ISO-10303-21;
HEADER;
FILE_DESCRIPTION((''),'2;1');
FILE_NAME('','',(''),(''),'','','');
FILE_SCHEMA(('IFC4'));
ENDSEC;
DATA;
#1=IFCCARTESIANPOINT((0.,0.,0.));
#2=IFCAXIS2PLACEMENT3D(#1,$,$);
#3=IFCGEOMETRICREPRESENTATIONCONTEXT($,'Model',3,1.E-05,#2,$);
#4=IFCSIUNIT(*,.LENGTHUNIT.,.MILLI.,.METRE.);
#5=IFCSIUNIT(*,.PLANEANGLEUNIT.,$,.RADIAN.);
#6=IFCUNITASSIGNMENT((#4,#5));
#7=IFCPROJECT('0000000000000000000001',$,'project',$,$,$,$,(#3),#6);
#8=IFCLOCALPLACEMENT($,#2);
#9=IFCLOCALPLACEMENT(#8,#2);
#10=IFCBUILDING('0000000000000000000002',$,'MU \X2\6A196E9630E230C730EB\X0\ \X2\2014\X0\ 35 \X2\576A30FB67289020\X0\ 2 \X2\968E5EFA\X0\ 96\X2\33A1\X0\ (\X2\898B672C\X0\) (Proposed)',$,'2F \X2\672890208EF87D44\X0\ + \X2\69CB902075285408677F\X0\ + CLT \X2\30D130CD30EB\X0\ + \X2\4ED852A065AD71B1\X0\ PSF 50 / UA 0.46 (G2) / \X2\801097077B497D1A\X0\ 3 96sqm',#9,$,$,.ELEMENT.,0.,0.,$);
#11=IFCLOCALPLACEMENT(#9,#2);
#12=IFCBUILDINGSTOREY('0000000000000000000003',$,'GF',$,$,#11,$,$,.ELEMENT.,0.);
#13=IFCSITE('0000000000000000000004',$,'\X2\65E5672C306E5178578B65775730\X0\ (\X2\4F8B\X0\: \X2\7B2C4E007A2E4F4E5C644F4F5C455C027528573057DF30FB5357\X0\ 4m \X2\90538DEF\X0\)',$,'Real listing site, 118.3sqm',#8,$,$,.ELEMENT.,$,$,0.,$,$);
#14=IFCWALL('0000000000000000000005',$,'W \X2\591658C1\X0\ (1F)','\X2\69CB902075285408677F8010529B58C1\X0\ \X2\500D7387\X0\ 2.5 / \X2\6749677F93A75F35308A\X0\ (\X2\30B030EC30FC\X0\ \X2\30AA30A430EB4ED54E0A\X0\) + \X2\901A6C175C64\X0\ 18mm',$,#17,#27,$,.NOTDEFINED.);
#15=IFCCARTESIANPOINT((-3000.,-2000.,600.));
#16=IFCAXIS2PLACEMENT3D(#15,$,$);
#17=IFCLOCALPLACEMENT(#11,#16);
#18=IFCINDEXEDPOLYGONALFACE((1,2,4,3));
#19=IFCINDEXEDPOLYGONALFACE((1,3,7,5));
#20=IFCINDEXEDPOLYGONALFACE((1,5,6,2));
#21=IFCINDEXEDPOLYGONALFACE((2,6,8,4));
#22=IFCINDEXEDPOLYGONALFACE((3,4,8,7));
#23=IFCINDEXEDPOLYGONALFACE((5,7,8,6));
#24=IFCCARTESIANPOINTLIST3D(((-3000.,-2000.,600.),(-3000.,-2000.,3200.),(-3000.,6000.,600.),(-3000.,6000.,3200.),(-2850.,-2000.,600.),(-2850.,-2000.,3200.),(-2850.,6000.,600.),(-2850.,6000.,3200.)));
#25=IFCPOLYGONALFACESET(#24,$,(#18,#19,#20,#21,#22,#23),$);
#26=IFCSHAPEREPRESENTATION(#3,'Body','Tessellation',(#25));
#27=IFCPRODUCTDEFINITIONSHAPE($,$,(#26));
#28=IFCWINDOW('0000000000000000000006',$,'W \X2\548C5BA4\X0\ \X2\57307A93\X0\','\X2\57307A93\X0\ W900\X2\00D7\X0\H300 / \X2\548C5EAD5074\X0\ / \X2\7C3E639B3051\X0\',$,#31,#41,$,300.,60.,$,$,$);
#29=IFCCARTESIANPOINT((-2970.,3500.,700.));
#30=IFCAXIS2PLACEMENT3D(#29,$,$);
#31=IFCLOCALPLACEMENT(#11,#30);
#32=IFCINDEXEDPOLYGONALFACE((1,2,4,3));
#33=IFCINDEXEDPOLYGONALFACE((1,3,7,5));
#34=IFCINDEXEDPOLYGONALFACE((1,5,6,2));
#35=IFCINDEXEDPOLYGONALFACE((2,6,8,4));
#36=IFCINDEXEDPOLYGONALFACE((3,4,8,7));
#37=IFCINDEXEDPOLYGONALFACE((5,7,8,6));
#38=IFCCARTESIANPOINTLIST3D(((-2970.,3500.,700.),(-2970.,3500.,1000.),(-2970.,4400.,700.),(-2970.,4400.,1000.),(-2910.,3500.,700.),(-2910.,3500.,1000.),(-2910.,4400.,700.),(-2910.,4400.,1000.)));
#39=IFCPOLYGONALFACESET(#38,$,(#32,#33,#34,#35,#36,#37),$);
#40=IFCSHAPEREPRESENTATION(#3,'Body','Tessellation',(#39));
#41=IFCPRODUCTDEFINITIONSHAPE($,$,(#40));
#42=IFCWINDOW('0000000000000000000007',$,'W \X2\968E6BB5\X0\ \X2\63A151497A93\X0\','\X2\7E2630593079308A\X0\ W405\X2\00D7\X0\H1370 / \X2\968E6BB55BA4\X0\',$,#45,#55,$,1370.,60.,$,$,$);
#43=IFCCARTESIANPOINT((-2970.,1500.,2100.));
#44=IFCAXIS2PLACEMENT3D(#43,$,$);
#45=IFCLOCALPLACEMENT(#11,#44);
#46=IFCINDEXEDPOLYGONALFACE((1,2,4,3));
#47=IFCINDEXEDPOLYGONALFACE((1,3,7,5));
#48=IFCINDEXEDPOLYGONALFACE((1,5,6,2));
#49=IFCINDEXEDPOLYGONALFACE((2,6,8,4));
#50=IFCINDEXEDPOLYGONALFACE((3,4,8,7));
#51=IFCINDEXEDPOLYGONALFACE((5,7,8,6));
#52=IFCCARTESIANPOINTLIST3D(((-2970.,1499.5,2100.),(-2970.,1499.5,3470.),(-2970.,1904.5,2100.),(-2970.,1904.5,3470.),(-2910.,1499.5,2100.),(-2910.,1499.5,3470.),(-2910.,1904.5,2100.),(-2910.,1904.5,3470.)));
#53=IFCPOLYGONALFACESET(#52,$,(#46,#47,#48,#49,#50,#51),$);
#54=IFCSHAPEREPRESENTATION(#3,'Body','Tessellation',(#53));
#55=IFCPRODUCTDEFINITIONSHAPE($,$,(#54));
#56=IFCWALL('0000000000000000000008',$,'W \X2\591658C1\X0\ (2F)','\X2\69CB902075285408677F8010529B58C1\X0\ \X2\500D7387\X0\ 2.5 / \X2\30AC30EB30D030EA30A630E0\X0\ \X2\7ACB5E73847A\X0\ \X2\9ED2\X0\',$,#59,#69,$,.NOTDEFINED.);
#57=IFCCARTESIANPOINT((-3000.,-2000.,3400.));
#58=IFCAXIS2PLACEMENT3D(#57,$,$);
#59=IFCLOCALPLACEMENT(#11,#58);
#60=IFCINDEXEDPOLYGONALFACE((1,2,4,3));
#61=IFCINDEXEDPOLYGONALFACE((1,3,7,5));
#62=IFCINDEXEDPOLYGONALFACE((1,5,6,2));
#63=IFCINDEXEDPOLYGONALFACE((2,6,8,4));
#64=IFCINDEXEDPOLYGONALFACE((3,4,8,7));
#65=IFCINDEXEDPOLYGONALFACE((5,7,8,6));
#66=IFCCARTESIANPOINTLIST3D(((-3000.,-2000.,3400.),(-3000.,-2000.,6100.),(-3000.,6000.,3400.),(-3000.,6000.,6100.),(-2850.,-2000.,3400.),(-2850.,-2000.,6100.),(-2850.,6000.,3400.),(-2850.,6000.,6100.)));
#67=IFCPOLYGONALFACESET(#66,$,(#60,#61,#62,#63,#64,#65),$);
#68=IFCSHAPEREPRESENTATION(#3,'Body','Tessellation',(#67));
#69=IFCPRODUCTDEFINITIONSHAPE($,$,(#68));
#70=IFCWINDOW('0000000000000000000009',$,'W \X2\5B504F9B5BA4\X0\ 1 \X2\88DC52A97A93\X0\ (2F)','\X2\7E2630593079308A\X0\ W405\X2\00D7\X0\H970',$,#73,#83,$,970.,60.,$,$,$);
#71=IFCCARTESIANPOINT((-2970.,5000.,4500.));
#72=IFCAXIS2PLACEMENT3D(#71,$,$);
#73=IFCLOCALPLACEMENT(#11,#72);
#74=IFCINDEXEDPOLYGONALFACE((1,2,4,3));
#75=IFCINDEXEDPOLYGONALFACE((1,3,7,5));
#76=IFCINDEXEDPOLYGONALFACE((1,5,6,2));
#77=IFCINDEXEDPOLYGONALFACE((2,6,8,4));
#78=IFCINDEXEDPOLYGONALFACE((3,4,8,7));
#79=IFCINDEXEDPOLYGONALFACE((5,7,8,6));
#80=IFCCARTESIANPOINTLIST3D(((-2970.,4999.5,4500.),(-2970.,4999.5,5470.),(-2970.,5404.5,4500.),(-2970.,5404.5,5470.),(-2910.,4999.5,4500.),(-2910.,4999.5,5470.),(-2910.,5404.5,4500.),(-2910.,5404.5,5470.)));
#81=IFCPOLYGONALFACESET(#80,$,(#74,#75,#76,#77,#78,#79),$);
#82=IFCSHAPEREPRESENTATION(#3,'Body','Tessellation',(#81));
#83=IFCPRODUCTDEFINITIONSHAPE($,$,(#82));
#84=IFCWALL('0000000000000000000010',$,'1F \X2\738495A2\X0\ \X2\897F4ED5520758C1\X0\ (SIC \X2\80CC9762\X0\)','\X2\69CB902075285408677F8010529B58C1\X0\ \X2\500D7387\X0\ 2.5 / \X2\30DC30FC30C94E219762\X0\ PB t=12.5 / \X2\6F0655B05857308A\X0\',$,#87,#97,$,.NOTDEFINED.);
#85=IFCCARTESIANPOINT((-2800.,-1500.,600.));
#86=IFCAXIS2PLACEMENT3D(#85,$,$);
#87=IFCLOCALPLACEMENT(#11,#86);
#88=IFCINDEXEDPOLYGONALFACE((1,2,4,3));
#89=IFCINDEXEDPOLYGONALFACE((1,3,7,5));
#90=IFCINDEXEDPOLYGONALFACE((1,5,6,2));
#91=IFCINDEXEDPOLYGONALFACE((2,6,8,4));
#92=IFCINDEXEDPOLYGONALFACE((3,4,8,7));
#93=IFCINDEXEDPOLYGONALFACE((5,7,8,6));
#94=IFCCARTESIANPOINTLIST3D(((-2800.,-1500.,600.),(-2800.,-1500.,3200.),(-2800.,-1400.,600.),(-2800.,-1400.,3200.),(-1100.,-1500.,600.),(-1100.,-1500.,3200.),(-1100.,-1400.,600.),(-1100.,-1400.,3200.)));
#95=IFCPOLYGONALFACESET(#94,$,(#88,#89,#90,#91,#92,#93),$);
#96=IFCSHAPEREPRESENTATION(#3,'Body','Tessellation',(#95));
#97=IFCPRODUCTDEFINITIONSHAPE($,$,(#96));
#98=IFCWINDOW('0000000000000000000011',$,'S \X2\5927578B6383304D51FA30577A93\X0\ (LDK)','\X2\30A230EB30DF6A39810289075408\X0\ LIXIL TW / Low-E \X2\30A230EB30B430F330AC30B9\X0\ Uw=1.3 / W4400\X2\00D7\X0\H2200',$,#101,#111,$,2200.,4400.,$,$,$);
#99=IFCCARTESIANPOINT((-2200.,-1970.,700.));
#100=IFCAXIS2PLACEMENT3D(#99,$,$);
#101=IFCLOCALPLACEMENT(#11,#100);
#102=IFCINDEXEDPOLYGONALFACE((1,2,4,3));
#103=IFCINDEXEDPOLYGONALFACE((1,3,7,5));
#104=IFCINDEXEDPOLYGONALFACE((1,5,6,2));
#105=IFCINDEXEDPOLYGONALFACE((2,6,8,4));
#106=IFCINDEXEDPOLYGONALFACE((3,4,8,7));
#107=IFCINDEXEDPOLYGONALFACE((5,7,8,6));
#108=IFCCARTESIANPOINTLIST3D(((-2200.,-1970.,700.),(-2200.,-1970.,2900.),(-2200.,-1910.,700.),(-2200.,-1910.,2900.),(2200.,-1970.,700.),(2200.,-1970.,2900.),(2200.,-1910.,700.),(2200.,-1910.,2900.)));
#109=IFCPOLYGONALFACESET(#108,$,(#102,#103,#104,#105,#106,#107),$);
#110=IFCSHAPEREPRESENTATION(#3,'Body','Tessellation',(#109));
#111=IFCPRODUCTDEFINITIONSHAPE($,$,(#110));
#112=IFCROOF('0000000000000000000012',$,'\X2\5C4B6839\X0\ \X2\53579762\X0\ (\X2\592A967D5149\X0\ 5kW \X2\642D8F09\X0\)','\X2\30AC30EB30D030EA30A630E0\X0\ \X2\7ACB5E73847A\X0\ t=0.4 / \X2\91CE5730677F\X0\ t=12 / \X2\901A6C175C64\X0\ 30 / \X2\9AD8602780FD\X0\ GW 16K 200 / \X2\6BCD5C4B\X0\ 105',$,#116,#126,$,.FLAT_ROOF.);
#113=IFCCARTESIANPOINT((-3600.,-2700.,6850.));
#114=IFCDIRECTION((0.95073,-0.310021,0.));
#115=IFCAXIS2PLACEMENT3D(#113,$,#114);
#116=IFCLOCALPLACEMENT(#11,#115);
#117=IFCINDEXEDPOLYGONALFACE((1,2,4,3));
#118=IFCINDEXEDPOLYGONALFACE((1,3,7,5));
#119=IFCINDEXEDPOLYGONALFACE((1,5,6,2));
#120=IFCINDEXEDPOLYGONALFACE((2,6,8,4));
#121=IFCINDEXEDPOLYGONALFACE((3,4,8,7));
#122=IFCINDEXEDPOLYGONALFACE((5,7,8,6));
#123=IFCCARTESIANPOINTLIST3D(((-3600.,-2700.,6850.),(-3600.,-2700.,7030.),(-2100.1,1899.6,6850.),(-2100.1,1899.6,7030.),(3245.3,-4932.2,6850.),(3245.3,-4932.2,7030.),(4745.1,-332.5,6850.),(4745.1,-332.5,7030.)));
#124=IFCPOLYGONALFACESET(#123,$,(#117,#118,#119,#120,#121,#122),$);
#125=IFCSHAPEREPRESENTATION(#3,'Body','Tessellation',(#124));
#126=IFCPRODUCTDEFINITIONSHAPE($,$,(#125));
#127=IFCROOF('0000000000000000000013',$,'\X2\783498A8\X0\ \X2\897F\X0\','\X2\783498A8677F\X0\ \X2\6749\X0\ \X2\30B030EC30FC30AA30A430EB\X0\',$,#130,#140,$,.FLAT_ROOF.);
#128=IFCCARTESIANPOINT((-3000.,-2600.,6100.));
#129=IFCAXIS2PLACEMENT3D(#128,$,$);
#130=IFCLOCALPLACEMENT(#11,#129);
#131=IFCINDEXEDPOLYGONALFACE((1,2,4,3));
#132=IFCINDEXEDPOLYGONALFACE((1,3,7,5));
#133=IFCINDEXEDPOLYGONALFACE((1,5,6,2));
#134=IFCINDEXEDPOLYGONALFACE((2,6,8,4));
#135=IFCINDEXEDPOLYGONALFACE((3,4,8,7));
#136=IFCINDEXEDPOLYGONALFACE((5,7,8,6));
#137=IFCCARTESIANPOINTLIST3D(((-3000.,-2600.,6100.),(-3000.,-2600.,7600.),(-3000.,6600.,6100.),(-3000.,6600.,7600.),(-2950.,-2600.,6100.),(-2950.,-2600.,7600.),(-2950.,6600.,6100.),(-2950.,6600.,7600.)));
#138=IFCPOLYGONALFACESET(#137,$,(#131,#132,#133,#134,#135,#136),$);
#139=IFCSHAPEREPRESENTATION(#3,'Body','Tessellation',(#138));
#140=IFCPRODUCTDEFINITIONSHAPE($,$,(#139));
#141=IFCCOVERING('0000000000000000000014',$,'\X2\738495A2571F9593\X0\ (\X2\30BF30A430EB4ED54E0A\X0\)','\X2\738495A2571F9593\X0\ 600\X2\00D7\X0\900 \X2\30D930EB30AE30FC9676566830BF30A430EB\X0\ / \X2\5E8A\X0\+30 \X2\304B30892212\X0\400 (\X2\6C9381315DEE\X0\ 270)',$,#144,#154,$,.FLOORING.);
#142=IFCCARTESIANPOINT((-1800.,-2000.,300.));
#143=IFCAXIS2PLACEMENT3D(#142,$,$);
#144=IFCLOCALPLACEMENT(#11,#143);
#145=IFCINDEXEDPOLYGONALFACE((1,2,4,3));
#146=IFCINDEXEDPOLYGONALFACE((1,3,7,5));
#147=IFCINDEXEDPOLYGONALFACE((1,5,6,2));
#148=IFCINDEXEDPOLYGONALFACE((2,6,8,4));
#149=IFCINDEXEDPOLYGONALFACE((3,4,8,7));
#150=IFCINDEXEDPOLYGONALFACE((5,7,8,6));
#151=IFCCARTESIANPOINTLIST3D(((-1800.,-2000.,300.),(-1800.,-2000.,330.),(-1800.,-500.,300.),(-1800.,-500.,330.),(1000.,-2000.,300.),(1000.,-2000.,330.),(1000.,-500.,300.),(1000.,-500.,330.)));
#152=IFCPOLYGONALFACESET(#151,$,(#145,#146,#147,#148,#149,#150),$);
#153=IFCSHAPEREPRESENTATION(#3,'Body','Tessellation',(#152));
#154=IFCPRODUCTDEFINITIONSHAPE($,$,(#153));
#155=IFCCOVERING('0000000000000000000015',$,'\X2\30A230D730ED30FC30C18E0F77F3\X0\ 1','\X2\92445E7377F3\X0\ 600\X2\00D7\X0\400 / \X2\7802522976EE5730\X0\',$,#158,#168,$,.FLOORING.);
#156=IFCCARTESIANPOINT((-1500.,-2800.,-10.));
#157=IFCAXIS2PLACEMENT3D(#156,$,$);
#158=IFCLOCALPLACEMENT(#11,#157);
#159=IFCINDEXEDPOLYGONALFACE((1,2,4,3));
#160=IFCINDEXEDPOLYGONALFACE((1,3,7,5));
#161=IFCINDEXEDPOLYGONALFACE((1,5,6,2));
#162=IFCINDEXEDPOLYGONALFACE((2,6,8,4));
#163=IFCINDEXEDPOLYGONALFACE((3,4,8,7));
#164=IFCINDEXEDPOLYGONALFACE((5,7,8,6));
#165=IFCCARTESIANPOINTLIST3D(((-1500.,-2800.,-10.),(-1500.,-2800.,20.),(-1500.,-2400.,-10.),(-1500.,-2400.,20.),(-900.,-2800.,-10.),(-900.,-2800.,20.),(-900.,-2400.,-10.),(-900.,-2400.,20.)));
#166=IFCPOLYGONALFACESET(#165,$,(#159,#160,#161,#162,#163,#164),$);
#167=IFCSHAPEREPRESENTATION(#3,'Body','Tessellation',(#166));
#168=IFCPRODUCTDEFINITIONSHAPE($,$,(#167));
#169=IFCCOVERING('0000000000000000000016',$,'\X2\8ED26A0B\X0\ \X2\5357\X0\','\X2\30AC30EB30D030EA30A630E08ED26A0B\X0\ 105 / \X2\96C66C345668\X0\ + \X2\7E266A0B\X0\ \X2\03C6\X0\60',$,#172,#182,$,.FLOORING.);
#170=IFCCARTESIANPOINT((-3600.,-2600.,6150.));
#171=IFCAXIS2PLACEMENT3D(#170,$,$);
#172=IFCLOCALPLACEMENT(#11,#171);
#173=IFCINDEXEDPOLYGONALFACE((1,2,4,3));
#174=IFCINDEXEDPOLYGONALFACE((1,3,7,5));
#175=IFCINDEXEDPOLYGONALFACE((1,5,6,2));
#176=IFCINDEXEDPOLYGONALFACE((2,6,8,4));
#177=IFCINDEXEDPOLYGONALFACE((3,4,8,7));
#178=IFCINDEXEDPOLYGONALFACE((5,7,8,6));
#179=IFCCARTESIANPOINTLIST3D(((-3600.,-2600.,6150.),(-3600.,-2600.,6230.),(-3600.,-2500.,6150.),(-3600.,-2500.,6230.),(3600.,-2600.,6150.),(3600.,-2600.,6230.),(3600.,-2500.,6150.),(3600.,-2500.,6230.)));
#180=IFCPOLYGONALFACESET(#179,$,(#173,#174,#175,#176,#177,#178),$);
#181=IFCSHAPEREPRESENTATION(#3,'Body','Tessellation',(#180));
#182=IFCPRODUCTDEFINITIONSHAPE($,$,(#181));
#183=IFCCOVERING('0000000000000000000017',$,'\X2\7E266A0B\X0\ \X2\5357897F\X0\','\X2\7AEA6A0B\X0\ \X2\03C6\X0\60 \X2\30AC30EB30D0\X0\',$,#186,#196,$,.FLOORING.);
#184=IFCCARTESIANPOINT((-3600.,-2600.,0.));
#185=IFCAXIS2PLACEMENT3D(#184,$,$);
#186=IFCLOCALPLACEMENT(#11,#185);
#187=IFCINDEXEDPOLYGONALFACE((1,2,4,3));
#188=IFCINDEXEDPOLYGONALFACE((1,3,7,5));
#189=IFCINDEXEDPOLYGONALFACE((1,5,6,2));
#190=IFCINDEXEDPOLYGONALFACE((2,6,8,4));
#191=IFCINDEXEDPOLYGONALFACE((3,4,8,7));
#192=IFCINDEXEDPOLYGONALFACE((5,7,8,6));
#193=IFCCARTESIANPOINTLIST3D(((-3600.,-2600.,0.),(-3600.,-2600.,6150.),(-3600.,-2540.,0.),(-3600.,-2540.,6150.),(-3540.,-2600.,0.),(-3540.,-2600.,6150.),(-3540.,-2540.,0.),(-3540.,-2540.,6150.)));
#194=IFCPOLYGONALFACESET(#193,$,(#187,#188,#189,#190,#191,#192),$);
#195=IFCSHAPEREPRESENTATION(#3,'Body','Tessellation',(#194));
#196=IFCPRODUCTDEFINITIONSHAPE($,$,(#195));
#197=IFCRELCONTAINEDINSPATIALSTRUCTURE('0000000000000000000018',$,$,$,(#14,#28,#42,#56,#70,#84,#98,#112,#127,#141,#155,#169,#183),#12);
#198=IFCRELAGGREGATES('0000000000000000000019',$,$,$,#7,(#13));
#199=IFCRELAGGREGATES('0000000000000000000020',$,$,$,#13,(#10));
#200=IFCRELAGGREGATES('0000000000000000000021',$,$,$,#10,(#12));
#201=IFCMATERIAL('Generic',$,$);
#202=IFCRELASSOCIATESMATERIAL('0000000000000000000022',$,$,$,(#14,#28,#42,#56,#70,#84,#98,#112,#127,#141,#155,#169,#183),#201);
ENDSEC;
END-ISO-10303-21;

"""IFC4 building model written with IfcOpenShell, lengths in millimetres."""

from ifc_helpers import new_model, si_unit, frame, frame_2d, origin, place, context, project, spatial, rectangle, extrude, material, element, fill, save


model = new_model("IFC4")

# Units and contexts
model_context = context("Model", 3, precision=1e-05, world=origin())
ifc_project = project(units=[si_unit("LENGTHUNIT", "METRE", prefix="MILLI"), si_unit("PLANEANGLEUNIT", "RADIAN")], contexts=[model_context])

# Site, building, storey
site_placement = place(None, origin())
site = spatial("IfcSite", under=ifc_project, at=site_placement, Name="日本の典型敷地 (例: 第一種低層住居専用地域・南 4m 道路)", ObjectType="Real listing site, 118.3sqm", CompositionType="ELEMENT", RefElevation=0.0)
building_placement = place(site_placement, origin())
building = spatial("IfcBuilding", under=site, at=building_placement, Name="MU 標準モデル — 35 坪・木造 2 階建 96㎡ (見本) (Proposed)", ObjectType="2F 木造軸組 + 構造用合板 + CLT パネル + 付加断熱 PSF 50 / UA 0.46 (G2) / 耐震等級 3 96sqm", CompositionType="ELEMENT", ElevationOfRefHeight=0.0, ElevationOfTerrain=0.0)
storey_placement = place(building_placement, origin())
storey = spatial("IfcBuildingStorey", under=building, at=storey_placement, Name="GF", CompositionType="ELEMENT", Elevation=0.0)

# Shared definitions
ifc_material_1 = material(Name="Generic")

# Wall, openings, windows
wall_1_placement = place(storey_placement, frame((-3000.0, -2000.0, 600.0)))
wall_1 = element("IfcWall", 1, at=wall_1_placement, inside=storey, material=ifc_material_1, Name="W 外壁 (1F)", Description="構造用合板耐力壁 倍率 2.5 / 杉板鎧張り (グレー オイル仕上) + 通気層 18mm", PredefinedType="NOTDEFINED", context=model_context, shape_type="SweptSolid", body=[
    extrude(rectangle(XDim=150.0, YDim=8000.0, at=frame_2d((75.0, 4000.0))), frame((-3000.0, -2000.0, 600.0)), (0.0, 0.0, 1.0), 2600.0),
])
opening_1_placement = place(storey_placement, frame((-2970.0, 3500.0, 700.0)))
opening_1 = element("IfcOpeningElement", 2, at=opening_1_placement, cuts=wall_1, PredefinedType="NOTDEFINED", context=model_context, shape_type="SweptSolid", body=[
    extrude(rectangle(XDim=60.0, YDim=900.0, at=frame_2d((30.0, 450.0))), frame((-2970.0, 3500.0, 700.0)), (0.0, 0.0, 1.0), 300.0),
])
opening_2_placement = place(storey_placement, frame((-2970.0, 1500.0, 2100.0)))
opening_2 = element("IfcOpeningElement", 3, at=opening_2_placement, cuts=wall_1, PredefinedType="NOTDEFINED", context=model_context, shape_type="SweptSolid", body=[
    extrude(rectangle(XDim=60.0, YDim=405.0, at=frame_2d((30.0, 202.0))), frame((-2970.0, 1500.0, 2100.0)), (0.0, 0.0, 1.0), 1370.0),
])
window_1_placement = place(storey_placement, frame((-2970.0, 3500.0, 700.0)))
window_1 = element("IfcWindow", 4, at=window_1_placement, inside=storey, material=ifc_material_1, Name="W 和室 地窓", Description="地窓 W900×H300 / 和庭側 / 簾掛け", OverallHeight=300.0, OverallWidth=60.0, context=model_context, shape_type="SweptSolid", body=[
    extrude(rectangle(XDim=60.0, YDim=900.0, at=frame_2d((30.0, 450.0))), frame((-2970.0, 3500.0, 700.0)), (0.0, 0.0, 1.0), 300.0),
])
fill(opening_1, window_1)
window_2_placement = place(storey_placement, frame((-2970.0, 1500.0, 2100.0)))
window_2 = element("IfcWindow", 5, at=window_2_placement, inside=storey, material=ifc_material_1, Name="W 階段 採光窓", Description="縦すべり W405×H1370 / 階段室", OverallHeight=1370.0, OverallWidth=60.0, context=model_context, shape_type="SweptSolid", body=[
    extrude(rectangle(XDim=60.0, YDim=405.0, at=frame_2d((30.0, 202.0))), frame((-2970.0, 1500.0, 2100.0)), (0.0, 0.0, 1.0), 1370.0),
])
fill(opening_2, window_2)

# Wall, opening, window
wall_2_placement = place(storey_placement, frame((-3000.0, -2000.0, 3400.0)))
wall_2 = element("IfcWall", 6, at=wall_2_placement, inside=storey, material=ifc_material_1, Name="W 外壁 (2F)", Description="構造用合板耐力壁 倍率 2.5 / ガルバリウム 立平葺 黒", PredefinedType="NOTDEFINED", context=model_context, shape_type="SweptSolid", body=[
    extrude(rectangle(XDim=150.0, YDim=8000.0, at=frame_2d((75.0, 4000.0))), frame((-3000.0, -2000.0, 3400.0)), (0.0, 0.0, 1.0), 2700.0),
])
opening_3_placement = place(storey_placement, frame((-2970.0, 5000.0, 4500.0)))
opening_3 = element("IfcOpeningElement", 7, at=opening_3_placement, cuts=wall_2, PredefinedType="NOTDEFINED", context=model_context, shape_type="SweptSolid", body=[
    extrude(rectangle(XDim=60.0, YDim=405.0, at=frame_2d((30.0, 202.0))), frame((-2970.0, 5000.0, 4500.0)), (0.0, 0.0, 1.0), 970.0),
])
window_3_placement = place(storey_placement, frame((-2970.0, 5000.0, 4500.0)))
window_3 = element("IfcWindow", 8, at=window_3_placement, inside=storey, material=ifc_material_1, Name="W 子供室 1 補助窓 (2F)", Description="縦すべり W405×H970", OverallHeight=970.0, OverallWidth=60.0, context=model_context, shape_type="SweptSolid", body=[
    extrude(rectangle(XDim=60.0, YDim=405.0, at=frame_2d((30.0, 202.0))), frame((-2970.0, 5000.0, 4500.0)), (0.0, 0.0, 1.0), 970.0),
])
fill(opening_3, window_3)

# Wall
wall_3_placement = place(storey_placement, frame((-2800.0, -1500.0, 600.0)))
element("IfcWall", 9, at=wall_3_placement, inside=storey, material=ifc_material_1, Name="1F 玄関 西仕切壁 (SIC 背面)", Description="構造用合板耐力壁 倍率 2.5 / ボード両面 PB t=12.5 / 漆喰塗り", PredefinedType="NOTDEFINED", context=model_context, shape_type="SweptSolid", body=[
    extrude(rectangle(XDim=1700.0, YDim=100.0, at=frame_2d((850.0, 50.0))), frame((-2800.0, -1500.0, 600.0)), (0.0, 0.0, 1.0), 2600.0),
])

# Window
window_4_placement = place(storey_placement, frame((-2200.0, -1970.0, 700.0)))
element("IfcWindow", 10, at=window_4_placement, inside=storey, material=ifc_material_1, Name="S 大型掃き出し窓 (LDK)", Description="アルミ樹脂複合 LIXIL TW / Low-E アルゴンガス Uw=1.3 / W4400×H2200", OverallHeight=2200.0, OverallWidth=4400.0, context=model_context, shape_type="SweptSolid", body=[
    extrude(rectangle(XDim=4400.0, YDim=60.0, at=frame_2d((2200.0, 30.0))), frame((-2200.0, -1970.0, 700.0)), (0.0, 0.0, 1.0), 2200.0),
])

# Roofs
roof_1_placement = place(storey_placement, frame((-3600.0, -2700.0, 6850.0), x_axis=(0.95073, -0.310021, 0.0)))
element("IfcRoof", 11, at=roof_1_placement, inside=storey, material=ifc_material_1, Name="屋根 南面 (太陽光 5kW 搭載)", Description="ガルバリウム 立平葺 t=0.4 / 野地板 t=12 / 通気層 30 / 高性能 GW 16K 200 / 母屋 105", PredefinedType="FLAT_ROOF", context=model_context, shape_type="SweptSolid", body=[
    extrude(rectangle(XDim=7200.0, YDim=4838.0, at=frame_2d((3600.0, 2419.0))), frame((-3600.0, -2700.0, 6850.0), x_axis=(0.95073, -0.310021, 0.0)), (0.0, 0.0, 1.0), 180.0),
])
roof_2_placement = place(storey_placement, frame((-3000.0, -2600.0, 6100.0)))
element("IfcRoof", 12, at=roof_2_placement, inside=storey, material=ifc_material_1, Name="破風 西", Description="破風板 杉 グレーオイル", PredefinedType="FLAT_ROOF", context=model_context, shape_type="SweptSolid", body=[
    extrude(rectangle(XDim=50.0, YDim=9200.0, at=frame_2d((25.0, 4600.0))), frame((-3000.0, -2600.0, 6100.0)), (0.0, 0.0, 1.0), 1500.0),
])

# Coverings
covering_1_placement = place(storey_placement, frame((-1800.0, -2000.0, 300.0)))
element("IfcCovering", 13, at=covering_1_placement, inside=storey, material=ifc_material_1, Name="玄関土間 (タイル仕上)", Description="玄関土間 600×900 ベルギー陶器タイル / 床+30 から−400 (沓脱差 270)", PredefinedType="FLOORING", context=model_context, shape_type="SweptSolid", body=[
    extrude(rectangle(XDim=2800.0, YDim=1500.0, at=frame_2d((1400.0, 750.0))), frame((-1800.0, -2000.0, 300.0)), (0.0, 0.0, 1.0), 30.0),
])
covering_2_placement = place(storey_placement, frame((-1500.0, -2800.0, -10.0)))
element("IfcCovering", 14, at=covering_2_placement, inside=storey, material=ifc_material_1, Name="アプローチ踏石 1", Description="鉄平石 600×400 / 砂利目地", PredefinedType="FLOORING", context=model_context, shape_type="SweptSolid", body=[
    extrude(rectangle(XDim=600.0, YDim=400.0, at=frame_2d((300.0, 200.0))), frame((-1500.0, -2800.0, -10.0)), (0.0, 0.0, 1.0), 30.0),
])
covering_3_placement = place(storey_placement, frame((-3600.0, -2600.0, 6150.0)))
element("IfcCovering", 15, at=covering_3_placement, inside=storey, material=ifc_material_1, Name="軒樋 南", Description="ガルバリウム軒樋 105 / 集水器 + 縦樋 φ60", PredefinedType="FLOORING", context=model_context, shape_type="SweptSolid", body=[
    extrude(rectangle(XDim=7200.0, YDim=100.0, at=frame_2d((3600.0, 50.0))), frame((-3600.0, -2600.0, 6150.0)), (0.0, 0.0, 1.0), 80.0),
])
covering_4_placement = place(storey_placement, frame((-3600.0, -2600.0, 0.0)))
element("IfcCovering", 16, at=covering_4_placement, inside=storey, material=ifc_material_1, Name="縦樋 南西", Description="竪樋 φ60 ガルバ", PredefinedType="FLOORING", context=model_context, shape_type="SweptSolid", body=[
    extrude(rectangle(XDim=60.0, YDim=60.0, at=frame_2d((30.0, 30.0))), frame((-3600.0, -2600.0, 0.0)), (0.0, 0.0, 1.0), 6150.0),
])

save(model, "model.ifc")
